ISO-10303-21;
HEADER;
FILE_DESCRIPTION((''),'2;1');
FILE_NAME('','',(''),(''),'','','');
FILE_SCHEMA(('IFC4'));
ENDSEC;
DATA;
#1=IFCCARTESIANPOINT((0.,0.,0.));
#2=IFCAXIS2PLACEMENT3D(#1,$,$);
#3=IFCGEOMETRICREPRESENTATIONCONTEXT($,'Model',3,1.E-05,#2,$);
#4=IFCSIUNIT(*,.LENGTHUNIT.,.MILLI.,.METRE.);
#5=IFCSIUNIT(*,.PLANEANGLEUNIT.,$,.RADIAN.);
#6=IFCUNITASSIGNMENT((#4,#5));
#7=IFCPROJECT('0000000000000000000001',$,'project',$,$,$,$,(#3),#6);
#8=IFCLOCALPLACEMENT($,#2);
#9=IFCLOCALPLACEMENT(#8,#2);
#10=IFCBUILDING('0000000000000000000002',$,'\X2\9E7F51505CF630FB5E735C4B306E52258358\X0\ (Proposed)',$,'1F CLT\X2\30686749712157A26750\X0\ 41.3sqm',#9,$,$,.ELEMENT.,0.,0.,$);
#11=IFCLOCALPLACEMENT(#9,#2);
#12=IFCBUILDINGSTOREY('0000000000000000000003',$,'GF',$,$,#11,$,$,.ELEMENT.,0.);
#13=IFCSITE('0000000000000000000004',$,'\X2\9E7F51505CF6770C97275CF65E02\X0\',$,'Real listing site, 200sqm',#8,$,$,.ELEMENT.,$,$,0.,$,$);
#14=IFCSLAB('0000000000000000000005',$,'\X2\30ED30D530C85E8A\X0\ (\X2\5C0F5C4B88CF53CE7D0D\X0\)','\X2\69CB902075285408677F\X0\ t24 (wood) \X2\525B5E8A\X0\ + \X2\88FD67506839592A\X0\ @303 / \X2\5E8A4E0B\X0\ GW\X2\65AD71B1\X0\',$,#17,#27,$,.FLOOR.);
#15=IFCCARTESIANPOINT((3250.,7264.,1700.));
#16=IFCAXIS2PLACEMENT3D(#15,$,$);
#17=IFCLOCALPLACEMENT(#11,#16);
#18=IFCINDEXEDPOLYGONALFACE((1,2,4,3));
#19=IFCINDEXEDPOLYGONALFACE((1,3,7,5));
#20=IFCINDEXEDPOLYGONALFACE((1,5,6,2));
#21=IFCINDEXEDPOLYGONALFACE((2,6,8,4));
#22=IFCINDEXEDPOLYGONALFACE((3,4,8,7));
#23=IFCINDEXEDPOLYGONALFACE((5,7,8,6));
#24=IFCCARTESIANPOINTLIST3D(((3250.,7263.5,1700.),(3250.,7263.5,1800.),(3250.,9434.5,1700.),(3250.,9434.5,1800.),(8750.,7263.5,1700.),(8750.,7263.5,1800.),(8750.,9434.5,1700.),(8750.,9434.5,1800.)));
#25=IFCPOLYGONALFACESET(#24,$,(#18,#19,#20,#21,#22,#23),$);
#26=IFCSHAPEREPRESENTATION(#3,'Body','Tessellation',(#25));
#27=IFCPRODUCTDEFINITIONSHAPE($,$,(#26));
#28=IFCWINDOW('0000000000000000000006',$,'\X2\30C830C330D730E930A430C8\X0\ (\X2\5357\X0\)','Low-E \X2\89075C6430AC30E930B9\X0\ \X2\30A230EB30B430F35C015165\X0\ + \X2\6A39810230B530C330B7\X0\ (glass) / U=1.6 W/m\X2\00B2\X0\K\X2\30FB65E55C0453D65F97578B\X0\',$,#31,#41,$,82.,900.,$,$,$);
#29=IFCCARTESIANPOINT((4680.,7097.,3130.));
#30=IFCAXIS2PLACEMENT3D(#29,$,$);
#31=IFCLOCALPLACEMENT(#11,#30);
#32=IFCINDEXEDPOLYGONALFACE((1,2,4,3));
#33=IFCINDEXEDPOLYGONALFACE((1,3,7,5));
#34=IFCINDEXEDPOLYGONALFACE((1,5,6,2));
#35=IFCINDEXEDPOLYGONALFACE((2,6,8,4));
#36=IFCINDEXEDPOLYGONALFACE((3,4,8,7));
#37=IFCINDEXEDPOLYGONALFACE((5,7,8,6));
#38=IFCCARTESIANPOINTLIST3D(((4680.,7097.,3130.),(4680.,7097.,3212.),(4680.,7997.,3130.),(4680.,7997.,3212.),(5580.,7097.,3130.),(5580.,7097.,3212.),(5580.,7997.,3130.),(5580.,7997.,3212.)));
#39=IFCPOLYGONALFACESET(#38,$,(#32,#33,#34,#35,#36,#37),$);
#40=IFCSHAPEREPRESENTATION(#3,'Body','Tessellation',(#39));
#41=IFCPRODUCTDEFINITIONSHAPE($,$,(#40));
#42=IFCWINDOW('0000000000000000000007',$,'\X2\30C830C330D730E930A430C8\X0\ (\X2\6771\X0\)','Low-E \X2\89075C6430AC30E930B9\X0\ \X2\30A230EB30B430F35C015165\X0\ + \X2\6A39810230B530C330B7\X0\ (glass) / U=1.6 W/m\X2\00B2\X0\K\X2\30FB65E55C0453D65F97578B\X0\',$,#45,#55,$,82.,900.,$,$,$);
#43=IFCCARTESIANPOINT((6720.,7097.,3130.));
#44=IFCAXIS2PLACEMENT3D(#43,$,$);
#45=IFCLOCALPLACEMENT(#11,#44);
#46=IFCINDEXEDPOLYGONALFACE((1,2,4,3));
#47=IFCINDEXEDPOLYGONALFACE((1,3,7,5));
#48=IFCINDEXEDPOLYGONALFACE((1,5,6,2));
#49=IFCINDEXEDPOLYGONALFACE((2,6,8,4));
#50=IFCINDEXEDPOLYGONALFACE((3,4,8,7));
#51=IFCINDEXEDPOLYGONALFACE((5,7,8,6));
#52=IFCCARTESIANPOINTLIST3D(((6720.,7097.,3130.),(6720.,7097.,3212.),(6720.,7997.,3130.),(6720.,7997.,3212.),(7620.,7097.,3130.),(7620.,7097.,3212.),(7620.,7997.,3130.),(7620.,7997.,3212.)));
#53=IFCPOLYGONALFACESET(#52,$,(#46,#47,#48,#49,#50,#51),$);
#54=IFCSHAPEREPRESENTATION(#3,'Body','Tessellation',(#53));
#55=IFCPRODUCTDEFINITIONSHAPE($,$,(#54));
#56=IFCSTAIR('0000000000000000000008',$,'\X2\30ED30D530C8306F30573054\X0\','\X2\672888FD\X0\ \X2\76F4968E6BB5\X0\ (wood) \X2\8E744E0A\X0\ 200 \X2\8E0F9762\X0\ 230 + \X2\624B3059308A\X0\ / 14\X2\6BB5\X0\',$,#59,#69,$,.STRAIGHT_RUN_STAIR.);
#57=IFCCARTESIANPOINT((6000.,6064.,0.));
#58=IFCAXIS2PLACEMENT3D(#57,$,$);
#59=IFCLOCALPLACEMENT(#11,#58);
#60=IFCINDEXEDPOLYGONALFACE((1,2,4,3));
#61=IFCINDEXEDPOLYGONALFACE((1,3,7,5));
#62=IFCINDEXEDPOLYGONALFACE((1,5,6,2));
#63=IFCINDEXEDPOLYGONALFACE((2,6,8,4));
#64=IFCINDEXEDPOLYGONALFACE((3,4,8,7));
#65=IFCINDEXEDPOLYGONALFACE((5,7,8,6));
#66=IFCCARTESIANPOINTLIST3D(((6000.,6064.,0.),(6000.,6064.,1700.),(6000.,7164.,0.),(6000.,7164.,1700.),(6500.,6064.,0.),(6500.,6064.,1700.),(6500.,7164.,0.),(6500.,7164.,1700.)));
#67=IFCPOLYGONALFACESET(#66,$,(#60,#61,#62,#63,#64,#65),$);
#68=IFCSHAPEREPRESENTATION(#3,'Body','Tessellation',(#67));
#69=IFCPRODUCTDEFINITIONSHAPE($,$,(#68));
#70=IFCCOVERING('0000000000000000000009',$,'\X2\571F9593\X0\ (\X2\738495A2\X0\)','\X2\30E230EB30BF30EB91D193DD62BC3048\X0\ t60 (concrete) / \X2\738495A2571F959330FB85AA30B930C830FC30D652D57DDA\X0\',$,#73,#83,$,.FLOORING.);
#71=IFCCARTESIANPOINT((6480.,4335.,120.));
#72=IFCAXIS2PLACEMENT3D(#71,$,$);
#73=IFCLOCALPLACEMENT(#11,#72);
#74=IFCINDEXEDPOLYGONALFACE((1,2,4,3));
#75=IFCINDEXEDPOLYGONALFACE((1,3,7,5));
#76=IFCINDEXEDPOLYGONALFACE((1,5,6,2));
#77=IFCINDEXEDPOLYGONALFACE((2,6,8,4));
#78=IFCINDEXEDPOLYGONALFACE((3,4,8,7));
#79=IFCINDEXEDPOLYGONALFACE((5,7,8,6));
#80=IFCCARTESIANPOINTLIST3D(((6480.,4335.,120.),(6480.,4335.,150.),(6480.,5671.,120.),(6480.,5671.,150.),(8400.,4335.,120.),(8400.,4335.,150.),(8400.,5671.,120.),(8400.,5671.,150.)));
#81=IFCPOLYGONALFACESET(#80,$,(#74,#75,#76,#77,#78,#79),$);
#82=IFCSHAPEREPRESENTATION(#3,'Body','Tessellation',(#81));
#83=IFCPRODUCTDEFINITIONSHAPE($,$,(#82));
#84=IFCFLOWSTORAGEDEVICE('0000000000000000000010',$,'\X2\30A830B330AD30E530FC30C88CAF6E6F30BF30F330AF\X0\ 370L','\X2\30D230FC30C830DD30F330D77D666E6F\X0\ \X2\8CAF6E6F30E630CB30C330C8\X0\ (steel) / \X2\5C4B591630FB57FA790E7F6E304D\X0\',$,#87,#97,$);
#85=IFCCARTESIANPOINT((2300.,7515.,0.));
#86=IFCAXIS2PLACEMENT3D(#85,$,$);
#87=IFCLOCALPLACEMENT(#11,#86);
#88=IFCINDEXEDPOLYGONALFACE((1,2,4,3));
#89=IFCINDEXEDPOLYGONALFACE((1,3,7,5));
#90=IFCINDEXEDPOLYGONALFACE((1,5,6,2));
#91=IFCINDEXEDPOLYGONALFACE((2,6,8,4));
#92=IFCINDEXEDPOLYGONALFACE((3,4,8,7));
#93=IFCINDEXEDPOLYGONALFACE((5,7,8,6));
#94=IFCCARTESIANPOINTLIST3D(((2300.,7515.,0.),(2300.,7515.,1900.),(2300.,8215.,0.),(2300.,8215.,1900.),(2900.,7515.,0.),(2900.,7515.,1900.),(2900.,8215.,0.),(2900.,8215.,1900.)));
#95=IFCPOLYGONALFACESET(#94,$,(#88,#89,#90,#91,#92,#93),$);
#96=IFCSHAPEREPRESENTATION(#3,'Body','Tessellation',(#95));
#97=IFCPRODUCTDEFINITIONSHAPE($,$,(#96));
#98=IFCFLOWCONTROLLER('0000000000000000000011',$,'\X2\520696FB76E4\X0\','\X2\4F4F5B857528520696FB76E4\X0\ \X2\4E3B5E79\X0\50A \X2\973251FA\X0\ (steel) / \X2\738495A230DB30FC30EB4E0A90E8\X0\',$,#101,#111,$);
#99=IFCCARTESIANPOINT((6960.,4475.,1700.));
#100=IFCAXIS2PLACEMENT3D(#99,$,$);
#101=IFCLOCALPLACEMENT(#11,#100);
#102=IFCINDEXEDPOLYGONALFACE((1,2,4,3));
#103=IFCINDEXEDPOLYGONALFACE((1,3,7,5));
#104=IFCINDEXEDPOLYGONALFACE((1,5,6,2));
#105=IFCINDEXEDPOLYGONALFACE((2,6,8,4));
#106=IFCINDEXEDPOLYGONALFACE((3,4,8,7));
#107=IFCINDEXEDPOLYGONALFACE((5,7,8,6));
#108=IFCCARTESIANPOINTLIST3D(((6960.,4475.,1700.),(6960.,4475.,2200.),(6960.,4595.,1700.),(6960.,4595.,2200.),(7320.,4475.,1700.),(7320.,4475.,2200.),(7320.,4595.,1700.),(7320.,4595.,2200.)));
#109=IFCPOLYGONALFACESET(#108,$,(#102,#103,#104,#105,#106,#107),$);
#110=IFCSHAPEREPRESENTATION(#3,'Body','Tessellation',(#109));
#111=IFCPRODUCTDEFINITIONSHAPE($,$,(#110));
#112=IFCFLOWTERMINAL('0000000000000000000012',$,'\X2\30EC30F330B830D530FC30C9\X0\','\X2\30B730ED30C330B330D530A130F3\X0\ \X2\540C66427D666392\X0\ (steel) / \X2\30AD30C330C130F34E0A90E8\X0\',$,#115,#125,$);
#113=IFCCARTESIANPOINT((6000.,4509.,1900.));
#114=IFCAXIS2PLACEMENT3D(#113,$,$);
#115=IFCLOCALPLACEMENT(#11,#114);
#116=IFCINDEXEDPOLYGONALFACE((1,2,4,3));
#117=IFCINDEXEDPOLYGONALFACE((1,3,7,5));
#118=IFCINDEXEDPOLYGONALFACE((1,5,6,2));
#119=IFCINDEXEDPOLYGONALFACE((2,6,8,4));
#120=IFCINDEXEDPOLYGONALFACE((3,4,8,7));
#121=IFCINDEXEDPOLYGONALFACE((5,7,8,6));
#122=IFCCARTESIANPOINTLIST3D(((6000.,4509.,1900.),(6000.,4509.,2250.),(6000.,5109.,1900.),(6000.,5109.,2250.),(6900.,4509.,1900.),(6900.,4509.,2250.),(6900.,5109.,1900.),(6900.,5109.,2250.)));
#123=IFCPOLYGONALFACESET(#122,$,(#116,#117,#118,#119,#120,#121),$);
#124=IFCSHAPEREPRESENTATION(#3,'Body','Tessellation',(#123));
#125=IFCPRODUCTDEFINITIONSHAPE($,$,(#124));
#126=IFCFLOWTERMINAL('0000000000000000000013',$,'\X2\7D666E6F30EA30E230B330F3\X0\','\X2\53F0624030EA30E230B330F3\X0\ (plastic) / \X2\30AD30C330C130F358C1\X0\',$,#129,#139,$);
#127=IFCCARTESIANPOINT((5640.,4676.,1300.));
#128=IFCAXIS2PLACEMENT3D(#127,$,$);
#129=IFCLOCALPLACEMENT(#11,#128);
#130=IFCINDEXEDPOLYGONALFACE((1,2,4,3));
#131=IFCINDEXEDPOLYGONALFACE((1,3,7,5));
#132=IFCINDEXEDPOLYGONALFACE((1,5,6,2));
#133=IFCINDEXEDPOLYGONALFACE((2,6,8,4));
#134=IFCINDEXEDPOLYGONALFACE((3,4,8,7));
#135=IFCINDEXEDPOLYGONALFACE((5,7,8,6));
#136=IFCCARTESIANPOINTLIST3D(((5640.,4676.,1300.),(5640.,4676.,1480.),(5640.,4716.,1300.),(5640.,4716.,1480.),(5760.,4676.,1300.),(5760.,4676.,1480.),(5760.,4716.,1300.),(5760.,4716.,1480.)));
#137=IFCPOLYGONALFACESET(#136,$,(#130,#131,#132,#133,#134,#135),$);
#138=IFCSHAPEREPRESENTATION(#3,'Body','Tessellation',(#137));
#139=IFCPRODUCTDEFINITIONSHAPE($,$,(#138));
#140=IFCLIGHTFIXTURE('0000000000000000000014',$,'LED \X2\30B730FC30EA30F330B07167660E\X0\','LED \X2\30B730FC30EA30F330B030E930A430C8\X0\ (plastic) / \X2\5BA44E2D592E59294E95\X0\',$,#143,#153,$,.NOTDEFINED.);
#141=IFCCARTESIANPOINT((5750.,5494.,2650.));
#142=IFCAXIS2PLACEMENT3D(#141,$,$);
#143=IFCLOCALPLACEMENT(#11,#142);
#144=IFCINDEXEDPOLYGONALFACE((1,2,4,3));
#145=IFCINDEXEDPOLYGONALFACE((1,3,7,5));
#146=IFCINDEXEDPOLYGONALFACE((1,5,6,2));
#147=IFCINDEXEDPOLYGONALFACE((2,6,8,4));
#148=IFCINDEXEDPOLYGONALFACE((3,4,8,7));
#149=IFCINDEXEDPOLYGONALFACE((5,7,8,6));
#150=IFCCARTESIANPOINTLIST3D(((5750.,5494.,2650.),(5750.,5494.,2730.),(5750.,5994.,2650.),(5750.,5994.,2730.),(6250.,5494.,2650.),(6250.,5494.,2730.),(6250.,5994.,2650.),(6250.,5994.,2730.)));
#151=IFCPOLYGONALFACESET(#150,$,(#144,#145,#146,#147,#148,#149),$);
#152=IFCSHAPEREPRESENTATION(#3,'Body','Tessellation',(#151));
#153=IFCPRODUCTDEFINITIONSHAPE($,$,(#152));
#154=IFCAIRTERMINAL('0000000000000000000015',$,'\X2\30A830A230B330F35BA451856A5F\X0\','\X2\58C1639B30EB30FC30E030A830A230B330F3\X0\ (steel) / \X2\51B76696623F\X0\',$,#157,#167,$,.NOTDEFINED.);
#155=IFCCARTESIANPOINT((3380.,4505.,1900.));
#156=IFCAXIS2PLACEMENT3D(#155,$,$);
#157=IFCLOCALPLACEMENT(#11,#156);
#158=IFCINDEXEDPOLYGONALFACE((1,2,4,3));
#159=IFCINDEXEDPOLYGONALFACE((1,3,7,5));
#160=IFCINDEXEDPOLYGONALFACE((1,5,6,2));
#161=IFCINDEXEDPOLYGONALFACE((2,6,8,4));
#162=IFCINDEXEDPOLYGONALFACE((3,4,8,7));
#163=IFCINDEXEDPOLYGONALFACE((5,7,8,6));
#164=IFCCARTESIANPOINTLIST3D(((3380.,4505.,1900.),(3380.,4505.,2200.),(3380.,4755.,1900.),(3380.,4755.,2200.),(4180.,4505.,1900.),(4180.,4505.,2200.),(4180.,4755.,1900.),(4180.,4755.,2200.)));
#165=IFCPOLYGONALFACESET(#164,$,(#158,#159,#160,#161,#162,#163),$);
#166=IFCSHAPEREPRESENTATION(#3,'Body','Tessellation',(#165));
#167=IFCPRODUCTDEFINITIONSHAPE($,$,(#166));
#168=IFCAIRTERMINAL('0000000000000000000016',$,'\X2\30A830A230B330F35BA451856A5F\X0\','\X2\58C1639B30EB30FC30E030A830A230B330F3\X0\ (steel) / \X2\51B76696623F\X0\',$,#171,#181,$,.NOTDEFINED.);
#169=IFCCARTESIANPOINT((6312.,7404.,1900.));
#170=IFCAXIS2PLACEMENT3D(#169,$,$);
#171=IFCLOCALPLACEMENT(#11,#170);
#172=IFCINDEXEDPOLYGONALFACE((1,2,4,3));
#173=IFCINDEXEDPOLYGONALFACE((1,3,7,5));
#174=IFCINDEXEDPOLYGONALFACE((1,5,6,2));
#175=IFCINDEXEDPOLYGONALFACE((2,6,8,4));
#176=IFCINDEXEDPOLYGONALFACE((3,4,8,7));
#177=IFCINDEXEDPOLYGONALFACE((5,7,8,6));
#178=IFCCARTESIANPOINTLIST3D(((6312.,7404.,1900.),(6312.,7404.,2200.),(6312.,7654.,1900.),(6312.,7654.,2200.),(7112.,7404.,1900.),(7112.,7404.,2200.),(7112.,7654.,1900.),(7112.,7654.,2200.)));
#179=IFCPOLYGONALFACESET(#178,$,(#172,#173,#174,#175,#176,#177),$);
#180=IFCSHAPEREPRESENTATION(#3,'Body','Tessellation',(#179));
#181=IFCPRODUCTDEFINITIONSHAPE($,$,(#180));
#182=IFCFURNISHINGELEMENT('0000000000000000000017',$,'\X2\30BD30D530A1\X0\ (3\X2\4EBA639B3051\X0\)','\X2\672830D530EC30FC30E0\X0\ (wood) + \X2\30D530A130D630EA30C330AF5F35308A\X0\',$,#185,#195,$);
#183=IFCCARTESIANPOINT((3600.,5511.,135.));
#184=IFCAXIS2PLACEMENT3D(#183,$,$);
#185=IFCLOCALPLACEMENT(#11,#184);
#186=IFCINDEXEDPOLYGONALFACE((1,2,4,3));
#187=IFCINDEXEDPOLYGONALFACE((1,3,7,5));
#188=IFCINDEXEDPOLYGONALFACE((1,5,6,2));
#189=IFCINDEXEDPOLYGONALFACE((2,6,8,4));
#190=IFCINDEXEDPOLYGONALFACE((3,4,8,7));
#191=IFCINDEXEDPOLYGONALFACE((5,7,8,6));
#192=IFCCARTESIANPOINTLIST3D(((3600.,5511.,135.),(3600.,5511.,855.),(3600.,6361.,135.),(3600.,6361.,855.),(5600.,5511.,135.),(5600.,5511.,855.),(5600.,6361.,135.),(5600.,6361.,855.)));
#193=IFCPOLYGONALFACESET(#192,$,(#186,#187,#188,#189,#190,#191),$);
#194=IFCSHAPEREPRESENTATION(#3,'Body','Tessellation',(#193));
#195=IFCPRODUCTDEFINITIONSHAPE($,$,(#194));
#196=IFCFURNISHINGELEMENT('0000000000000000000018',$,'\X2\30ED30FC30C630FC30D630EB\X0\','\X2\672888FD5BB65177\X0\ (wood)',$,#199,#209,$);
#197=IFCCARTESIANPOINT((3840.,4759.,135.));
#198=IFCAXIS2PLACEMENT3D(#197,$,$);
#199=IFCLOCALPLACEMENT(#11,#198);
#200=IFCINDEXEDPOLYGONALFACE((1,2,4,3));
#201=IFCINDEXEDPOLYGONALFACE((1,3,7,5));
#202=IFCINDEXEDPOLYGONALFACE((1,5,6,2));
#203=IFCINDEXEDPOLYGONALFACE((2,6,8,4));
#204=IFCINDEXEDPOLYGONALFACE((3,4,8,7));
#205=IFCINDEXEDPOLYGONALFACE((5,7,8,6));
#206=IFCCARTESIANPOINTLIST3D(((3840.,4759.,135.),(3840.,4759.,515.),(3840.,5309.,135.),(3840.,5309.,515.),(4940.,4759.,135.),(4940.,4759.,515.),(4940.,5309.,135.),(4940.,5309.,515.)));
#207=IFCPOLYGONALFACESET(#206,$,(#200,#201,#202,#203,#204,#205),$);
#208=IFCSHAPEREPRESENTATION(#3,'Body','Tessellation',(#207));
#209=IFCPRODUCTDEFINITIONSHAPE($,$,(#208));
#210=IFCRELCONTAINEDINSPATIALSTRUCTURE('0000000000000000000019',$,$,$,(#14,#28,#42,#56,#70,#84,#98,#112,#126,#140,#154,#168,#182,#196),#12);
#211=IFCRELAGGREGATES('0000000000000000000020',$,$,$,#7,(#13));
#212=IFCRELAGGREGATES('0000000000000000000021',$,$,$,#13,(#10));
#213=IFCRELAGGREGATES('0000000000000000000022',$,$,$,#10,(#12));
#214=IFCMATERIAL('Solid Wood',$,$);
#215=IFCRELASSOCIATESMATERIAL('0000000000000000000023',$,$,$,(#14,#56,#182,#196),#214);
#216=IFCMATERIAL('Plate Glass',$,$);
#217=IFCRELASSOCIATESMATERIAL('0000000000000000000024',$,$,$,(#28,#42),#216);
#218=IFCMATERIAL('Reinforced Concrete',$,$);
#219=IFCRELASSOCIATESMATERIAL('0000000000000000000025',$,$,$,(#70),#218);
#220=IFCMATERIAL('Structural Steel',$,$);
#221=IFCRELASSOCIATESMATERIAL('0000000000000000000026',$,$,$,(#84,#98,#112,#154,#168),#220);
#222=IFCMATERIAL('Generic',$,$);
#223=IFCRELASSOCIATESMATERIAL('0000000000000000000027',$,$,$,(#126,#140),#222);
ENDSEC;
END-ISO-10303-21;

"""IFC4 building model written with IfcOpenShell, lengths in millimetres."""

from ifc_helpers import new_model, si_unit, frame, frame_2d, origin, place, context, project, spatial, rectangle, extrude, material, element, save


model = new_model("IFC4")

# Units and contexts
model_context = context("Model", 3, precision=1e-05, world=origin())
ifc_project = project(units=[si_unit("LENGTHUNIT", "METRE", prefix="MILLI"), si_unit("PLANEANGLEUNIT", "RADIAN")], contexts=[model_context])

# Site, building, storey
site_placement = place(None, origin())
site = spatial("IfcSite", under=ifc_project, at=site_placement, Name="鹿児島県霧島市", ObjectType="Real listing site, 200sqm", CompositionType="ELEMENT", RefElevation=0.0)
building_placement = place(site_placement, origin())
building = spatial("IfcBuilding", under=site, at=building_placement, Name="鹿児島・平屋の別荘 (Proposed)", ObjectType="1F CLTと杉無垢材 41.3sqm", CompositionType="ELEMENT", ElevationOfRefHeight=0.0, ElevationOfTerrain=0.0)
storey_placement = place(building_placement, origin())
storey = spatial("IfcBuildingStorey", under=building, at=storey_placement, Name="GF", CompositionType="ELEMENT", Elevation=0.0)

# Shared definitions
ifc_material_1 = material(Name="Solid Wood")

# Slab
slab_placement = place(storey_placement, frame((3250.0, 7264.0, 1700.0)))
element("IfcSlab", 1, at=slab_placement, inside=storey, material=ifc_material_1, Name="ロフト床 (小屋裏収納)", Description="構造用合板 t24 (wood) 剛床 + 製材根太 @303 / 床下 GW断熱", PredefinedType="FLOOR", context=model_context, shape_type="SweptSolid", body=[
    extrude(rectangle(XDim=5500.0, YDim=2171.0, at=frame_2d((2750.0, 1085.0))), frame((3250.0, 7264.0, 1700.0)), (0.0, 0.0, 1.0), 100.0),
])

# Windows
ifc_material_2 = material(Name="Plate Glass")
window_1_placement = place(storey_placement, frame((4680.0, 7097.0, 3130.0)))
element("IfcWindow", 2, at=window_1_placement, inside=storey, material=ifc_material_2, Name="トップライト (南)", Description="Low-E 複層ガラス アルゴン封入 + 樹脂サッシ (glass) / U=1.6 W/m²K・日射取得型", OverallHeight=82.0, OverallWidth=900.0, context=model_context, shape_type="SweptSolid", body=[
    extrude(rectangle(XDim=900.0, YDim=900.0, at=frame_2d((450.0, 450.0))), frame((4680.0, 7097.0, 3130.0)), (0.0, 0.0, 1.0), 82.0),
])
window_2_placement = place(storey_placement, frame((6720.0, 7097.0, 3130.0)))
element("IfcWindow", 3, at=window_2_placement, inside=storey, material=ifc_material_2, Name="トップライト (東)", Description="Low-E 複層ガラス アルゴン封入 + 樹脂サッシ (glass) / U=1.6 W/m²K・日射取得型", OverallHeight=82.0, OverallWidth=900.0, context=model_context, shape_type="SweptSolid", body=[
    extrude(rectangle(XDim=900.0, YDim=900.0, at=frame_2d((450.0, 450.0))), frame((6720.0, 7097.0, 3130.0)), (0.0, 0.0, 1.0), 82.0),
])

# Stair
stair_placement = place(storey_placement, frame((6000.0, 6064.0, 0.0)))
element("IfcStair", 4, at=stair_placement, inside=storey, material=ifc_material_1, Name="ロフトはしご", Description="木製 直階段 (wood) 蹴上 200 踏面 230 + 手すり / 14段", PredefinedType="STRAIGHT_RUN_STAIR", context=model_context, shape_type="SweptSolid", body=[
    extrude(rectangle(XDim=500.0, YDim=1100.0, at=frame_2d((250.0, 550.0))), frame((6000.0, 6064.0, 0.0)), (0.0, 0.0, 1.0), 1700.0),
])

# Covering
ifc_material_3 = material(Name="Reinforced Concrete")
covering_placement = place(storey_placement, frame((6480.0, 4335.0, 120.0)))
element("IfcCovering", 5, at=covering_placement, inside=storey, material=ifc_material_3, Name="土間 (玄関)", Description="モルタル金鏝押え t60 (concrete) / 玄関土間・薪ストーブ動線", PredefinedType="FLOORING", context=model_context, shape_type="SweptSolid", body=[
    extrude(rectangle(XDim=1920.0, YDim=1336.0, at=frame_2d((960.0, 668.0))), frame((6480.0, 4335.0, 120.0)), (0.0, 0.0, 1.0), 30.0),
])

# Flow storage device
ifc_material_4 = material(Name="Structural Steel")
flow_storage_device_placement = place(storey_placement, frame((2300.0, 7515.0, 0.0)))
element("IfcFlowStorageDevice", 6, at=flow_storage_device_placement, inside=storey, material=ifc_material_4, Name="エコキュート貯湯タンク 370L", Description="ヒートポンプ給湯 貯湯ユニット (steel) / 屋外・基礎置き", context=model_context, shape_type="SweptSolid", body=[
    extrude(rectangle(XDim=600.0, YDim=700.0, at=frame_2d((300.0, 350.0))), frame((2300.0, 7515.0, 0.0)), (0.0, 0.0, 1.0), 1900.0),
])

# Flow controller
flow_controller_placement = place(storey_placement, frame((6960.0, 4475.0, 1700.0)))
element("IfcFlowController", 7, at=flow_controller_placement, inside=storey, material=ifc_material_4, Name="分電盤", Description="住宅用分電盤 主幹50A 露出 (steel) / 玄関ホール上部", context=model_context, shape_type="SweptSolid", body=[
    extrude(rectangle(XDim=360.0, YDim=120.0, at=frame_2d((180.0, 60.0))), frame((6960.0, 4475.0, 1700.0)), (0.0, 0.0, 1.0), 500.0),
])

# Flow terminals
flow_terminal_1_placement = place(storey_placement, frame((6000.0, 4509.0, 1900.0)))
element("IfcFlowTerminal", 8, at=flow_terminal_1_placement, inside=storey, material=ifc_material_4, Name="レンジフード", Description="シロッコファン 同時給排 (steel) / キッチン上部", context=model_context, shape_type="SweptSolid", body=[
    extrude(rectangle(XDim=900.0, YDim=600.0, at=frame_2d((450.0, 300.0))), frame((6000.0, 4509.0, 1900.0)), (0.0, 0.0, 1.0), 350.0),
])
ifc_material_5 = material(Name="Generic")
flow_terminal_2_placement = place(storey_placement, frame((5640.0, 4676.0, 1300.0)))
element("IfcFlowTerminal", 9, at=flow_terminal_2_placement, inside=storey, material=ifc_material_5, Name="給湯リモコン", Description="台所リモコン (plastic) / キッチン壁", context=model_context, shape_type="SweptSolid", body=[
    extrude(rectangle(XDim=120.0, YDim=40.0, at=frame_2d((60.0, 20.0))), frame((5640.0, 4676.0, 1300.0)), (0.0, 0.0, 1.0), 180.0),
])

# Light fixture
light_fixture_placement = place(storey_placement, frame((5750.0, 5494.0, 2650.0)))
element("IfcLightFixture", 10, at=light_fixture_placement, inside=storey, material=ifc_material_5, Name="LED シーリング照明", Description="LED シーリングライト (plastic) / 室中央天井", PredefinedType="NOTDEFINED", context=model_context, shape_type="SweptSolid", body=[
    extrude(rectangle(XDim=500.0, YDim=500.0, at=frame_2d((250.0, 250.0))), frame((5750.0, 5494.0, 2650.0)), (0.0, 0.0, 1.0), 80.0),
])

# Air terminals
air_terminal_1_placement = place(storey_placement, frame((3380.0, 4505.0, 1900.0)))
element("IfcAirTerminal", 11, at=air_terminal_1_placement, inside=storey, material=ifc_material_4, Name="エアコン室内機", Description="壁掛ルームエアコン (steel) / 冷暖房", PredefinedType="NOTDEFINED", context=model_context, shape_type="SweptSolid", body=[
    extrude(rectangle(XDim=800.0, YDim=250.0, at=frame_2d((400.0, 125.0))), frame((3380.0, 4505.0, 1900.0)), (0.0, 0.0, 1.0), 300.0),
])
air_terminal_2_placement = place(storey_placement, frame((6312.0, 7404.0, 1900.0)))
element("IfcAirTerminal", 12, at=air_terminal_2_placement, inside=storey, material=ifc_material_4, Name="エアコン室内機", Description="壁掛ルームエアコン (steel) / 冷暖房", PredefinedType="NOTDEFINED", context=model_context, shape_type="SweptSolid", body=[
    extrude(rectangle(XDim=800.0, YDim=250.0, at=frame_2d((400.0, 125.0))), frame((6312.0, 7404.0, 1900.0)), (0.0, 0.0, 1.0), 300.0),
])

# Furnishing elements
furnishing_1_placement = place(storey_placement, frame((3600.0, 5511.0, 135.0)))
element("IfcFurnishingElement", 13, at=furnishing_1_placement, inside=storey, material=ifc_material_1, Name="ソファ (3人掛け)", Description="木フレーム (wood) + ファブリック張り", context=model_context, shape_type="SweptSolid", body=[
    extrude(rectangle(XDim=2000.0, YDim=850.0, at=frame_2d((1000.0, 425.0))), frame((3600.0, 5511.0, 135.0)), (0.0, 0.0, 1.0), 720.0),
])
furnishing_2_placement = place(storey_placement, frame((3840.0, 4759.0, 135.0)))
element("IfcFurnishingElement", 14, at=furnishing_2_placement, inside=storey, material=ifc_material_1, Name="ローテーブル", Description="木製家具 (wood)", context=model_context, shape_type="SweptSolid", body=[
    extrude(rectangle(XDim=1100.0, YDim=550.0, at=frame_2d((550.0, 275.0))), frame((3840.0, 4759.0, 135.0)), (0.0, 0.0, 1.0), 380.0),
])

save(model, "model.ifc")
